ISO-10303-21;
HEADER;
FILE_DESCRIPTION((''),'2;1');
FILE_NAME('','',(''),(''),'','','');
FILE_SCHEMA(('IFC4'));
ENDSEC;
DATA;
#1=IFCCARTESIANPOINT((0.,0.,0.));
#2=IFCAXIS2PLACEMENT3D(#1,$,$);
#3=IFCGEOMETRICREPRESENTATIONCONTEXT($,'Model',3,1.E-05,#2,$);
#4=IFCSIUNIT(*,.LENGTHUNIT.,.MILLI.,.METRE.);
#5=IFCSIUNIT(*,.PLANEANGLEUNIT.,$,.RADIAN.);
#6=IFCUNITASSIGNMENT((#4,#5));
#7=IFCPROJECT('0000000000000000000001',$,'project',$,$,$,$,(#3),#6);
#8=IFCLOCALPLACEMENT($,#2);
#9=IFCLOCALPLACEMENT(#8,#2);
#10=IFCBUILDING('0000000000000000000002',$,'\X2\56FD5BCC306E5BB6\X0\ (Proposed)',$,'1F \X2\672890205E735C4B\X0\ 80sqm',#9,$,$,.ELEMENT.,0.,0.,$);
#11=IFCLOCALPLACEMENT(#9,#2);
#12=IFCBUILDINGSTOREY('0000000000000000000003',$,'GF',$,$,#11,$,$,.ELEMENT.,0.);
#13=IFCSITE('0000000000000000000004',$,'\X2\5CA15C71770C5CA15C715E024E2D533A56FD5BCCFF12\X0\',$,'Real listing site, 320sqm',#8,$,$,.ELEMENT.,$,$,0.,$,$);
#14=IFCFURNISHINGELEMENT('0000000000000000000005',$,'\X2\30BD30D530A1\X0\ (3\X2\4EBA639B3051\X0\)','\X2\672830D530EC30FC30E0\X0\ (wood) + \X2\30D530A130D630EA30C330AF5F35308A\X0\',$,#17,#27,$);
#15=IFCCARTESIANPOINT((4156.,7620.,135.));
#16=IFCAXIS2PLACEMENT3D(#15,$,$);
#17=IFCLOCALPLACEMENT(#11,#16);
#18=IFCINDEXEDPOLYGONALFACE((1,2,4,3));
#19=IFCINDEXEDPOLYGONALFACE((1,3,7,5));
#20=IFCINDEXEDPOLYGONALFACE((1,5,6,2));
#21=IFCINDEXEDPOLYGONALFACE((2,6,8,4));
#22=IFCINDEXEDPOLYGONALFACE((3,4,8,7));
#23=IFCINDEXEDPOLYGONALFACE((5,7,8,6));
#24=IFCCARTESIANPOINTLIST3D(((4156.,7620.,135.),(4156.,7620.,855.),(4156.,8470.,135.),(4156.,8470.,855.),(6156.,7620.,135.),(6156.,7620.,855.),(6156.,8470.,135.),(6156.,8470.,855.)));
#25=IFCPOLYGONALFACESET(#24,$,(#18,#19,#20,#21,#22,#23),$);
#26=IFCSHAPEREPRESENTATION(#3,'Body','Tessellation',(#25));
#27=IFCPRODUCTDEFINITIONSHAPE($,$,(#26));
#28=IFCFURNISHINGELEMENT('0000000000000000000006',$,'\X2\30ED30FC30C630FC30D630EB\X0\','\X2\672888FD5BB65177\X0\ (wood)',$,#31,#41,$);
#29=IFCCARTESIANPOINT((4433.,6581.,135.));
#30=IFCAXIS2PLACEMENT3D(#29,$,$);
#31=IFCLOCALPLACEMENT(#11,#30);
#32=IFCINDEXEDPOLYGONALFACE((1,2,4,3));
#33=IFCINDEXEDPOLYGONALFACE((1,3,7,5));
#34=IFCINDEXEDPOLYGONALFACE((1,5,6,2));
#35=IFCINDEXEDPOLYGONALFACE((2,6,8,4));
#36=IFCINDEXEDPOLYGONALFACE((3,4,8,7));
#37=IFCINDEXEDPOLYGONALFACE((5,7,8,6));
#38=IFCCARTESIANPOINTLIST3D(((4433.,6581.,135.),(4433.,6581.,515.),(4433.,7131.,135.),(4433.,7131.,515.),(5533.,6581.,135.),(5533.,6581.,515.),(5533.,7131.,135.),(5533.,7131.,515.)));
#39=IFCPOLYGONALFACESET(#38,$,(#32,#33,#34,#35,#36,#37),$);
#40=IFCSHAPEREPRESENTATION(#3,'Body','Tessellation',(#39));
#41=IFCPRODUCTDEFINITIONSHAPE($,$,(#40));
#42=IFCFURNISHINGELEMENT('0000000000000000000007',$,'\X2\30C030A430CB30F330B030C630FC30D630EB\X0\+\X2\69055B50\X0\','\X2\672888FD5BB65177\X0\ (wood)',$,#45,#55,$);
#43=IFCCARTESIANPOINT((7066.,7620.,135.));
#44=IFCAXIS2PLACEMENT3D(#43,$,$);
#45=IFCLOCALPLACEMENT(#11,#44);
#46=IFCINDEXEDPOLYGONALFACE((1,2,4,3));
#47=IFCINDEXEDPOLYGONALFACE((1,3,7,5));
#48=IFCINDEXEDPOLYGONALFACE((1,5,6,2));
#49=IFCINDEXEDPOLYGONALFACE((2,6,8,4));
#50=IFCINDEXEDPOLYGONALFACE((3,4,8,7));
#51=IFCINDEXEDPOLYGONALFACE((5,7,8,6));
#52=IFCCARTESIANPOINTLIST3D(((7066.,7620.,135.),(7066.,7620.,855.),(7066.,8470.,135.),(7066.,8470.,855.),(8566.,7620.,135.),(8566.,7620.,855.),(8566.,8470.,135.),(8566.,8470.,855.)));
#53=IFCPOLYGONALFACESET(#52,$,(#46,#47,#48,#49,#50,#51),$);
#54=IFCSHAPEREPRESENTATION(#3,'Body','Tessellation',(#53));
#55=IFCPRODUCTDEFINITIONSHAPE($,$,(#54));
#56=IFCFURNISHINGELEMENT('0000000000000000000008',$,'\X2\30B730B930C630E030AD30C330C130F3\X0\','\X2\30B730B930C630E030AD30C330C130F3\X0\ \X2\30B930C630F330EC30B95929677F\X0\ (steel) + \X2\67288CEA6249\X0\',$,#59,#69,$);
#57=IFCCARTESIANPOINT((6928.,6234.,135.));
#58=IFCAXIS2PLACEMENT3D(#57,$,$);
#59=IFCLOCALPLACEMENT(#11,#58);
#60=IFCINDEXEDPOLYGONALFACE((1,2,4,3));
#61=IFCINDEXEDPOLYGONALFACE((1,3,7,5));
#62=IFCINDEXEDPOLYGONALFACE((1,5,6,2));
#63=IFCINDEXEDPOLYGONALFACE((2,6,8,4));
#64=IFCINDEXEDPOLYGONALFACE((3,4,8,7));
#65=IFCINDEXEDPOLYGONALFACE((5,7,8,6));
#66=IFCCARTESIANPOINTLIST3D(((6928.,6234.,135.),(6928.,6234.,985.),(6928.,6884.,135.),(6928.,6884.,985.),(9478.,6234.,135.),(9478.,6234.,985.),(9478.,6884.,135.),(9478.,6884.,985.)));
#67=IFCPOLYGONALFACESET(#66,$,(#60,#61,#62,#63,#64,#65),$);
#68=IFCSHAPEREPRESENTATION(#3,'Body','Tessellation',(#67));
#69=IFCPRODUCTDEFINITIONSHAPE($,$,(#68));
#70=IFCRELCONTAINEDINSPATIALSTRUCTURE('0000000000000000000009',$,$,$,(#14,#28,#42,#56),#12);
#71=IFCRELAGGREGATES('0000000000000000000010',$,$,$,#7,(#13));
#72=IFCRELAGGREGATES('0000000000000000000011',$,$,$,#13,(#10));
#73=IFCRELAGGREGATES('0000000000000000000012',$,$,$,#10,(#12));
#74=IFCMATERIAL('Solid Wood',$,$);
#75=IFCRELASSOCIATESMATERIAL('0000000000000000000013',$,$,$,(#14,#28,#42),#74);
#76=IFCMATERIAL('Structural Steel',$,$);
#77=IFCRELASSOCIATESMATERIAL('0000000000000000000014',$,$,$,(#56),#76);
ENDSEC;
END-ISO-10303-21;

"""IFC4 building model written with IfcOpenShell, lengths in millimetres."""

from ifc_helpers import new_model, si_unit, frame, frame_2d, origin, place, context, project, spatial, rectangle, extrude, material, element, save


model = new_model("IFC4")

# Units and contexts
model_context = context("Model", 3, precision=1e-05, world=origin())
ifc_project = project(units=[si_unit("LENGTHUNIT", "METRE", prefix="MILLI"), si_unit("PLANEANGLEUNIT", "RADIAN")], contexts=[model_context])

# Site, building, storey
site_placement = place(None, origin())
site = spatial("IfcSite", under=ifc_project, at=site_placement, Name="岡山県岡山市中区国富２", ObjectType="Real listing site, 320sqm", CompositionType="ELEMENT", RefElevation=0.0)
building_placement = place(site_placement, origin())
building = spatial("IfcBuilding", under=site, at=building_placement, Name="国富の家 (Proposed)", ObjectType="1F 木造平屋 80sqm", CompositionType="ELEMENT", ElevationOfRefHeight=0.0, ElevationOfTerrain=0.0)
storey_placement = place(building_placement, origin())
storey = spatial("IfcBuildingStorey", under=building, at=storey_placement, Name="GF", CompositionType="ELEMENT", Elevation=0.0)

# Shared definitions
ifc_material_1 = material(Name="Solid Wood")

# Shared definitions
ifc_material_2 = material(Name="Structural Steel")

# Furnishing elements
furnishing_1_placement = place(storey_placement, frame((4156.0, 7620.0, 135.0)))
element("IfcFurnishingElement", 1, at=furnishing_1_placement, inside=storey, material=ifc_material_1, Name="ソファ (3人掛け)", Description="木フレーム (wood) + ファブリック張り", context=model_context, shape_type="SweptSolid", body=[
    extrude(rectangle(XDim=2000.0, YDim=850.0, at=frame_2d((1000.0, 425.0))), frame((4156.0, 7620.0, 135.0)), (0.0, 0.0, 1.0), 720.0),
])
furnishing_2_placement = place(storey_placement, frame((4433.0, 6581.0, 135.0)))
element("IfcFurnishingElement", 2, at=furnishing_2_placement, inside=storey, material=ifc_material_1, Name="ローテーブル", Description="木製家具 (wood)", context=model_context, shape_type="SweptSolid", body=[
    extrude(rectangle(XDim=1100.0, YDim=550.0, at=frame_2d((550.0, 275.0))), frame((4433.0, 6581.0, 135.0)), (0.0, 0.0, 1.0), 380.0),
])
furnishing_3_placement = place(storey_placement, frame((7066.0, 7620.0, 135.0)))
element("IfcFurnishingElement", 3, at=furnishing_3_placement, inside=storey, material=ifc_material_1, Name="ダイニングテーブル+椅子", Description="木製家具 (wood)", context=model_context, shape_type="SweptSolid", body=[
    extrude(rectangle(XDim=1500.0, YDim=850.0, at=frame_2d((750.0, 425.0))), frame((7066.0, 7620.0, 135.0)), (0.0, 0.0, 1.0), 720.0),
])
furnishing_4_placement = place(storey_placement, frame((6928.0, 6234.0, 135.0)))
element("IfcFurnishingElement", 4, at=furnishing_4_placement, inside=storey, material=ifc_material_2, Name="システムキッチン", Description="システムキッチン ステンレス天板 (steel) + 木質扉", context=model_context, shape_type="SweptSolid", body=[
    extrude(rectangle(XDim=2550.0, YDim=650.0, at=frame_2d((1275.0, 325.0))), frame((6928.0, 6234.0, 135.0)), (0.0, 0.0, 1.0), 850.0),
])

save(model, "model.ifc")
